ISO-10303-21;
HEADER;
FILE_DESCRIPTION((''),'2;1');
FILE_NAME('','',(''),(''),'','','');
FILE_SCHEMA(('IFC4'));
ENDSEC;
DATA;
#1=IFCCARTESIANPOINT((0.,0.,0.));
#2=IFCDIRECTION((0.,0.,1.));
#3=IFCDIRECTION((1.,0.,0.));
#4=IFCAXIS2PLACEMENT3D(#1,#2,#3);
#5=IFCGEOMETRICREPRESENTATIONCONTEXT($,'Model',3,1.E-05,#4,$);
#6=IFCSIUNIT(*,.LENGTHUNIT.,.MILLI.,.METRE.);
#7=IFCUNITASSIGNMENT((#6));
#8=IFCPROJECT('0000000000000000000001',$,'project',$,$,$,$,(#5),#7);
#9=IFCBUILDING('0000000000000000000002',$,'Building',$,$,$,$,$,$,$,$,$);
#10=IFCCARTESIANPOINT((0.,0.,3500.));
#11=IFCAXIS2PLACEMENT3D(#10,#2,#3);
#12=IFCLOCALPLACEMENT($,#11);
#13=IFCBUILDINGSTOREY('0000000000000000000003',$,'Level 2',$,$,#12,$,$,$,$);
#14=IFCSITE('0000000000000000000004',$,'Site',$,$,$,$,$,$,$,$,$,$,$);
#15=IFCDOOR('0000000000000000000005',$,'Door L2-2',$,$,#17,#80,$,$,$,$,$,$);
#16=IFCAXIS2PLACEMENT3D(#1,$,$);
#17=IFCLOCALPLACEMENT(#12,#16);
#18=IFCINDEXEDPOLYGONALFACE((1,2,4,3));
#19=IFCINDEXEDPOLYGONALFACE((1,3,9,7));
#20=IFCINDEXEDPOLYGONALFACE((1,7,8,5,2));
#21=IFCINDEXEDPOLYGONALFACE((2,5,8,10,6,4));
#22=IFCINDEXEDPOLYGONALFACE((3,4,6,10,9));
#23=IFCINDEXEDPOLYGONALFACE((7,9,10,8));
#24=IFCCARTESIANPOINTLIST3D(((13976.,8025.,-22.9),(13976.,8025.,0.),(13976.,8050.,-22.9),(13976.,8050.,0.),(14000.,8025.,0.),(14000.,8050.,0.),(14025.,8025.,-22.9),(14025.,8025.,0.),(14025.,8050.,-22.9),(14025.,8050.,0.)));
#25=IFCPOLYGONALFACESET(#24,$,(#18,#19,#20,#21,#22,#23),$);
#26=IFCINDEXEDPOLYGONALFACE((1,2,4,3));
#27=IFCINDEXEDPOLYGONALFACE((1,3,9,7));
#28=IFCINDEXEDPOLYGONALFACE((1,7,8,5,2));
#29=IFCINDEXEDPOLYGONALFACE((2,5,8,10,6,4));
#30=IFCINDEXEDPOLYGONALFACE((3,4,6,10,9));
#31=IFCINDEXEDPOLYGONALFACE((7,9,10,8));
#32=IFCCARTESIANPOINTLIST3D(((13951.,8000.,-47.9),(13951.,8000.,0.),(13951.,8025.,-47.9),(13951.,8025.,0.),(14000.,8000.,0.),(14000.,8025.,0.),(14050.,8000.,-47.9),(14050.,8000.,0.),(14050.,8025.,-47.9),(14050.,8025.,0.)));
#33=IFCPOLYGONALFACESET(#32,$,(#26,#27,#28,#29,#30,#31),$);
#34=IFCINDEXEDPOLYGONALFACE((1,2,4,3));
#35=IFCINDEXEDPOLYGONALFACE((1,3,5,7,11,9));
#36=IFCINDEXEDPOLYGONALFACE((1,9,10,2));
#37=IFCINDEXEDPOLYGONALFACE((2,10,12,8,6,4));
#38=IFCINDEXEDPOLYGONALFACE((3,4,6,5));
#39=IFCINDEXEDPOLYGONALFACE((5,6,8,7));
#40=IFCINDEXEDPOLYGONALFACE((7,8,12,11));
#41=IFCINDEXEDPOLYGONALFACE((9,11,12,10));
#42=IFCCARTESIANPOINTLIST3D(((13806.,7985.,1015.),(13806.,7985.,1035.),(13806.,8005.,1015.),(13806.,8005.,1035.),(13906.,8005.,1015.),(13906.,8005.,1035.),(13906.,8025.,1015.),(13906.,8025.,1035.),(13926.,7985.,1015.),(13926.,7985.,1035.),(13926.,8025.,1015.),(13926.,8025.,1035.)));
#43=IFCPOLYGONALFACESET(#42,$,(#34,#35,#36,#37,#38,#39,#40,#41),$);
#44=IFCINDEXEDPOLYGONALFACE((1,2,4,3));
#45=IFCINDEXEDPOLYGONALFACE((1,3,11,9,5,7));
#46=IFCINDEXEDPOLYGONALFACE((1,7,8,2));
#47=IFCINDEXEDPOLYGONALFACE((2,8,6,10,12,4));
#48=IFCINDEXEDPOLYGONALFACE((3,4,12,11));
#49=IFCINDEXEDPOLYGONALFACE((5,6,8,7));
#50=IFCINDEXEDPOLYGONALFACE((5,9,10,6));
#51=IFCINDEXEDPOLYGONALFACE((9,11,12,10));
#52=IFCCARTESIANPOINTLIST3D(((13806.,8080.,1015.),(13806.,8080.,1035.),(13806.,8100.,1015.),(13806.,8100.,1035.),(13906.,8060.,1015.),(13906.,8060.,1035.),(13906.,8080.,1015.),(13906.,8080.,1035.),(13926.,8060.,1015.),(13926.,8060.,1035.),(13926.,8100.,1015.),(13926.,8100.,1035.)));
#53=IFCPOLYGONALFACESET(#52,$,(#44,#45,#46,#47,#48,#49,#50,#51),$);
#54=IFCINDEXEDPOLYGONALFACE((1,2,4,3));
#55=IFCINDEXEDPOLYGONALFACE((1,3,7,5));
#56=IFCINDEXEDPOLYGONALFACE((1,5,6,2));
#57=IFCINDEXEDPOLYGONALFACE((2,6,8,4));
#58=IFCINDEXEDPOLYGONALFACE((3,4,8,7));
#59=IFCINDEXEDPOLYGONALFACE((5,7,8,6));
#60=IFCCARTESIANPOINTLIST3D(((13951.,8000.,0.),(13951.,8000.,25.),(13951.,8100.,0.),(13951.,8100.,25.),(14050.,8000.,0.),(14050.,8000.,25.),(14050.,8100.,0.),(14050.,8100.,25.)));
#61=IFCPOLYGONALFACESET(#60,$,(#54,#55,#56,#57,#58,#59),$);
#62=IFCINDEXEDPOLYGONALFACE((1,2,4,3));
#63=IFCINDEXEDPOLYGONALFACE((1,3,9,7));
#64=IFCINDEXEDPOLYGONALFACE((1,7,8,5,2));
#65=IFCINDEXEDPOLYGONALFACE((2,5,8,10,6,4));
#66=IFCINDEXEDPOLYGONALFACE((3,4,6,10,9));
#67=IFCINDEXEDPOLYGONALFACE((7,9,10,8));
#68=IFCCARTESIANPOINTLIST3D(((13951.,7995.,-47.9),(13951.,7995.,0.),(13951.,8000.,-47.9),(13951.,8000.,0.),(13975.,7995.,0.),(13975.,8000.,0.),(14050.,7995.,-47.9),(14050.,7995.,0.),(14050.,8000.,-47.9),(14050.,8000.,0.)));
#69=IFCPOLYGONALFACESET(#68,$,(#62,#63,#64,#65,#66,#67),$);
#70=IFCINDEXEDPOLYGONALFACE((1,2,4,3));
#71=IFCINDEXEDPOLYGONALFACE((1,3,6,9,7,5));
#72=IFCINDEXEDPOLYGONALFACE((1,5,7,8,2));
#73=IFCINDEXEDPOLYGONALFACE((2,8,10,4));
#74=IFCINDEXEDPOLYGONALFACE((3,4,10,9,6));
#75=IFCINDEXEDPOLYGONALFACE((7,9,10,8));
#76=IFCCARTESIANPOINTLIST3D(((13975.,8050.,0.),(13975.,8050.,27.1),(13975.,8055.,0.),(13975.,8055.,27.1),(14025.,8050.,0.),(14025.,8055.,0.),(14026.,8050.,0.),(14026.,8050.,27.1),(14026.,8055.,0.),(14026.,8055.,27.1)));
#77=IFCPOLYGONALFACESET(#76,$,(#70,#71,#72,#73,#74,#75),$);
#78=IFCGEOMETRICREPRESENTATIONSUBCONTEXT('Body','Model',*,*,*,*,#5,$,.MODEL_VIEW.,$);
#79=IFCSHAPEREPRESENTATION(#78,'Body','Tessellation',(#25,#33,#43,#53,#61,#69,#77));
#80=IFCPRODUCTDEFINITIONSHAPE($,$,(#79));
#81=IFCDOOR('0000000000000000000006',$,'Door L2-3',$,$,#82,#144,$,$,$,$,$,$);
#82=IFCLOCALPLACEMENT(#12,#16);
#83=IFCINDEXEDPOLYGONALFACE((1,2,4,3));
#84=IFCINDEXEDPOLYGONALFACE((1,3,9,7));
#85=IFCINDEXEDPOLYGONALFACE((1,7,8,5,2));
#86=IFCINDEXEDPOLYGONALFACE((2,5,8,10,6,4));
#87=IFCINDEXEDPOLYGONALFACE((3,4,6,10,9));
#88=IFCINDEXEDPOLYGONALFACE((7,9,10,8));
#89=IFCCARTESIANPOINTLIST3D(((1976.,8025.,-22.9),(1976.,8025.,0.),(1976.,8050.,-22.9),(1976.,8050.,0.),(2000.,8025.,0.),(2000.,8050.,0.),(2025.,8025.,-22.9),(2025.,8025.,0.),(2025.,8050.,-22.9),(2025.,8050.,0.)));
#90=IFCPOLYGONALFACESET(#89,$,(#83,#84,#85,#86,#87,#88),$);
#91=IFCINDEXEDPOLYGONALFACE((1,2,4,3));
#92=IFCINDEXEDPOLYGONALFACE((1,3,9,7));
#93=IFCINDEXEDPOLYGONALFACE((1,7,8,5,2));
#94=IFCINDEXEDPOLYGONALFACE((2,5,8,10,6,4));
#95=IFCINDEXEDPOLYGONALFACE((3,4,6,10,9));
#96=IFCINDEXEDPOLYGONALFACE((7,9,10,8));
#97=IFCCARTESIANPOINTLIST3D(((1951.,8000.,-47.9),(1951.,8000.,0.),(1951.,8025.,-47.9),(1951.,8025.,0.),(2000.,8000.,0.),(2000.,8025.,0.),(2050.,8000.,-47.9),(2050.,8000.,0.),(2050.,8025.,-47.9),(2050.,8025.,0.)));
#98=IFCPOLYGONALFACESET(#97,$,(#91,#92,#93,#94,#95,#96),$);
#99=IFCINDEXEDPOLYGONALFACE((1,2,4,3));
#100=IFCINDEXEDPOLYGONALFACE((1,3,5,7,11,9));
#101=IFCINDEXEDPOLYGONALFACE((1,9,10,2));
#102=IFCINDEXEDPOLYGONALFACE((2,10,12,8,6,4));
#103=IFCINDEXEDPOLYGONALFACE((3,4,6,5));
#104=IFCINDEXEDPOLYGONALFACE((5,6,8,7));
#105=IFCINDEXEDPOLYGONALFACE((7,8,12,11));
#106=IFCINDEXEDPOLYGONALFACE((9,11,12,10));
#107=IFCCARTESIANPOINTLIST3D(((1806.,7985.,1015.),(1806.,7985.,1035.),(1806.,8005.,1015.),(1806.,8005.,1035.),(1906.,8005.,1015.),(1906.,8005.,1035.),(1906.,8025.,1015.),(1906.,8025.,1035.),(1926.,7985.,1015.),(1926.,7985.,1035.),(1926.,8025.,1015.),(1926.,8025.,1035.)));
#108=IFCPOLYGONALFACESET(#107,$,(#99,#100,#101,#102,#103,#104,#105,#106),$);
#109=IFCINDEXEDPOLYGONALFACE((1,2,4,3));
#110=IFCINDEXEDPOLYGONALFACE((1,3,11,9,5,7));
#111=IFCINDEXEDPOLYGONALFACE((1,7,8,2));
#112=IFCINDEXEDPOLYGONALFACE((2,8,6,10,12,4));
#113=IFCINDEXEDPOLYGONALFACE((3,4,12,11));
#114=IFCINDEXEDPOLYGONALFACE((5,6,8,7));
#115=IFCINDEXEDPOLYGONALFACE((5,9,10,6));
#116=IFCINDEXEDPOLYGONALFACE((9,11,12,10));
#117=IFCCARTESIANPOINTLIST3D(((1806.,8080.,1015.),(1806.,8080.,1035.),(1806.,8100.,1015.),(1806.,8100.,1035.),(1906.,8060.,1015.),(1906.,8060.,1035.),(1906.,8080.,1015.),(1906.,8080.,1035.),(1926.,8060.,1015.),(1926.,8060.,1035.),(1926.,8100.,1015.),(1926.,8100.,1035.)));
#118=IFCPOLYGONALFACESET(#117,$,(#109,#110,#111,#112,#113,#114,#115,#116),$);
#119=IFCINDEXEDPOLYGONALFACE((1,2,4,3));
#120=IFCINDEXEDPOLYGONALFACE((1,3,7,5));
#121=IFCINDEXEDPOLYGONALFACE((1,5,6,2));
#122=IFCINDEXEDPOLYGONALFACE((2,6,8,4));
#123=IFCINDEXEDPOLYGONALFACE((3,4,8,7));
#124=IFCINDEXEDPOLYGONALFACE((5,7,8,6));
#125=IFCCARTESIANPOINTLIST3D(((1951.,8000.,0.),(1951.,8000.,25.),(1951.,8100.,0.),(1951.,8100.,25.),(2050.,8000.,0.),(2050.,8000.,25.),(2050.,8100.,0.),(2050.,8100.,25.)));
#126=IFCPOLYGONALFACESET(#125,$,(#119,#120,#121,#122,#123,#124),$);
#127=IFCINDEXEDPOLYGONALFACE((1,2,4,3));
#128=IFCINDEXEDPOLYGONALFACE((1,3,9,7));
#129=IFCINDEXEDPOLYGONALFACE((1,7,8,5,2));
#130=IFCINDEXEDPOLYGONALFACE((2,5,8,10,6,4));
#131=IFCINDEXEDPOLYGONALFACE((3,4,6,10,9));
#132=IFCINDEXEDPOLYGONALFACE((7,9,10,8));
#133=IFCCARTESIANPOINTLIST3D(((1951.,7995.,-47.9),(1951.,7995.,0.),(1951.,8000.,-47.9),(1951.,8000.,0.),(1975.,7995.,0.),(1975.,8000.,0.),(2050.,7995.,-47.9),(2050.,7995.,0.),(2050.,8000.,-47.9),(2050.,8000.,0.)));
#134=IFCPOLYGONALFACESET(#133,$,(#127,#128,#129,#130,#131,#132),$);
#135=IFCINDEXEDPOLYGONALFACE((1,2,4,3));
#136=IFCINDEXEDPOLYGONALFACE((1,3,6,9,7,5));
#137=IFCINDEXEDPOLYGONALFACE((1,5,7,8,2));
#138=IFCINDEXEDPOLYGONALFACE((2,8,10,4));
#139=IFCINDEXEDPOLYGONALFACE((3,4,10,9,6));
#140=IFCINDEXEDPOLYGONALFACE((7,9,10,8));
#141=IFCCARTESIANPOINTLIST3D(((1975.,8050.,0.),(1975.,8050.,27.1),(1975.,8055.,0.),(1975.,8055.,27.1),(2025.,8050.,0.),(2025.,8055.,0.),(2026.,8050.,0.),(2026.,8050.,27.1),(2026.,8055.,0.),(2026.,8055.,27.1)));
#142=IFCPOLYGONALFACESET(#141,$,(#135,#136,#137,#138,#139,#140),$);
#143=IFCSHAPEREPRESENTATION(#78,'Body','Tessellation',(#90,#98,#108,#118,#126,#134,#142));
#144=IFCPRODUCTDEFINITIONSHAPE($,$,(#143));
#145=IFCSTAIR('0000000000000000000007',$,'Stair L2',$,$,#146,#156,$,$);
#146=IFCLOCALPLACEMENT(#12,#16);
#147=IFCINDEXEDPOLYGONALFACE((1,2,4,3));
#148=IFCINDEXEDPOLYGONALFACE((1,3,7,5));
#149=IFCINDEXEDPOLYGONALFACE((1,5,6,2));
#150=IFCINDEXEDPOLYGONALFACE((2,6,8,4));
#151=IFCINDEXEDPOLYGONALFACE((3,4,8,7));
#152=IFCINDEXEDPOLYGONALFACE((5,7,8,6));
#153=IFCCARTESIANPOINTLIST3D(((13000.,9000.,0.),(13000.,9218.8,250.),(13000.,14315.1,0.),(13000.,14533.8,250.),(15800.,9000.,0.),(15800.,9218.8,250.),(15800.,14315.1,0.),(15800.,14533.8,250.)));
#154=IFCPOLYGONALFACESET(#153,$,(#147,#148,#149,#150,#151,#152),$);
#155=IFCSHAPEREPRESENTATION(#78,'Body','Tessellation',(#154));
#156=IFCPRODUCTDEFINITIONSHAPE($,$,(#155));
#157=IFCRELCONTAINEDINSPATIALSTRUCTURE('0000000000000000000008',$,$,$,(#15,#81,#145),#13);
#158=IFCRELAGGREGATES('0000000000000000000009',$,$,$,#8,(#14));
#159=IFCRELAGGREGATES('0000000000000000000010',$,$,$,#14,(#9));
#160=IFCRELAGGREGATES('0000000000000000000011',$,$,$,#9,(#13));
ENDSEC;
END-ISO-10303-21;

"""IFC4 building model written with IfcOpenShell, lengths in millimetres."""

from ifc_helpers import new_model, si_unit, frame, origin_with_axes, place, context, subcontext, project, spatial, line, indexed_curve, outline, extrude, element, save


model = new_model("IFC4")

# Units and contexts
model_context = context("Model", 3, precision=1e-05, world=origin_with_axes())
body_context = subcontext(model_context, "Body", "Model", "MODEL_VIEW")
ifc_project = project(units=[si_unit("LENGTHUNIT", "METRE", prefix="MILLI")], contexts=[model_context])

# Site, building, storey
site = spatial("IfcSite", under=ifc_project, Name="Site")
building = spatial("IfcBuilding", under=site, Name="Building")
storey_placement = place(None, frame((0.0, 0.0, 3500.0), z_axis=(0.0, 0.0, 1.0), x_axis=(1.0, 0.0, 0.0)))
storey = spatial("IfcBuildingStorey", under=building, at=storey_placement, Name="Level 2")

# Doors
door_1_placement = place(storey_placement, frame((14000.0, 8000.0, 0.0), z_axis=(0.0, 0.0, 1.0), x_axis=(1.0, 0.0, 0.0)))
element("IfcDoor", 1, at=door_1_placement, inside=storey, Name="Door L2-2", context=body_context, shape_type="SweptSolid", body=[
    extrude(outline(indexed_curve([(0.0, 0.0), (0.0, 2.1), (1.0, 2.1), (1.0, 0.0), (-24.0, 0.0), (-24.0, -22.9), (25.0, -22.9), (25.0, 0.0)], segments=[line(1, 2, 3, 4, 5, 6, 7, 8, 1)])), frame((0.0, 25.0, 0.0), z_axis=(0.0, -1.0, 0.0), x_axis=(1.0, 0.0, 0.0)), (0.0, 0.0, -1.0), 25.0),
    extrude(outline(indexed_curve([(0.0, 0.0), (0.0, 2.1), (1.0, 2.1), (1.0, 0.0), (-49.0, 0.0), (-49.0, -47.9), (50.0, -47.9), (50.0, 0.0)], segments=[line(1, 2, 3, 4, 5, 6, 7, 8, 1)])), frame((0.0, 0.0, 0.0), z_axis=(0.0, -1.0, 0.0), x_axis=(1.0, 0.0, 0.0)), (0.0, 0.0, -1.0), 25.0),
    extrude(outline(indexed_curve([(0.0, 0.0), (-49.0, 0.0), (-49.0, 35.0), (0.0, 35.0)], segments=[line(1, 2, 3, 4, 1)])), frame((25.0, 25.0, 25.0), z_axis=(0.0, 0.0, 1.0), x_axis=(1.0, 0.0, 0.0)), (0.0, 0.0, 1.0), -47.9),
    extrude(outline(indexed_curve([(0.0, 0.0), (0.0, -40.0), (-120.0, -40.0), (-120.0, -20.0), (-20.0, -20.0), (-20.0, 0.0)], segments=[line(1, 2, 3, 4, 5, 6, 1)])), frame((-74.0, 25.0, 1015.0), z_axis=(0.0, 0.0, 1.0), x_axis=(1.0, 0.0, 0.0)), (0.0, 0.0, 1.0), 20.0),
    extrude(outline(indexed_curve([(0.0, 0.0), (0.0, 40.0), (-120.0, 40.0), (-120.0, 20.0), (-20.0, 20.0), (-20.0, 0.0)], segments=[line(1, 2, 3, 4, 5, 6, 1)])), frame((-74.0, 60.0, 1015.0), z_axis=(0.0, 0.0, 1.0), x_axis=(1.0, 0.0, 0.0)), (0.0, 0.0, 1.0), 20.0),
    extrude(outline(indexed_curve([(0.0, 0.0), (-99.0, 0.0), (-99.0, 100.0), (0.0, 100.0)], segments=[line(1, 2, 3, 4, 1)])), frame((50.0, 0.0, 0.0), z_axis=(0.0, 0.0, 1.0), x_axis=(1.0, 0.0, 0.0)), (0.0, 0.0, 1.0), 25.0),
    extrude(outline(indexed_curve([(0.0, 0.0), (0.0, 27.1), (51.0, 27.1), (51.0, 0.0), (-24.0, 0.0), (-24.0, -47.9), (75.0, -47.9), (75.0, 0.0)], segments=[line(1, 2, 3, 4, 5, 6, 7, 8, 1)])), frame((-25.0, -5.0, 0.0), z_axis=(0.0, -1.0, 0.0), x_axis=(1.0, 0.0, 0.0)), (0.0, 0.0, -1.0), 5.0),
    extrude(outline(indexed_curve([(0.0, 0.0), (0.0, 27.1), (51.0, 27.1), (51.0, 0.0), (1.0, 0.0), (1.0, -22.9), (50.0, -22.9), (50.0, 0.0)], segments=[line(1, 2, 3, 4, 5, 6, 7, 8, 1)])), frame((-25.0, 50.0, 0.0), z_axis=(0.0, -1.0, 0.0), x_axis=(1.0, 0.0, 0.0)), (0.0, 0.0, -1.0), 5.0),
])
door_2_placement = place(storey_placement, frame((2000.0, 8000.0, 0.0), z_axis=(0.0, 0.0, 1.0), x_axis=(1.0, 0.0, 0.0)))
element("IfcDoor", 2, at=door_2_placement, inside=storey, Name="Door L2-3", context=body_context, shape_type="SweptSolid", body=[
    extrude(outline(indexed_curve([(0.0, 0.0), (0.0, 2.1), (1.0, 2.1), (1.0, 0.0), (-24.0, 0.0), (-24.0, -22.9), (25.0, -22.9), (25.0, 0.0)], segments=[line(1, 2, 3, 4, 5, 6, 7, 8, 1)])), frame((0.0, 25.0, 0.0), z_axis=(0.0, -1.0, 0.0), x_axis=(1.0, 0.0, 0.0)), (0.0, 0.0, -1.0), 25.0),
    extrude(outline(indexed_curve([(0.0, 0.0), (0.0, 2.1), (1.0, 2.1), (1.0, 0.0), (-49.0, 0.0), (-49.0, -47.9), (50.0, -47.9), (50.0, 0.0)], segments=[line(1, 2, 3, 4, 5, 6, 7, 8, 1)])), frame((0.0, 0.0, 0.0), z_axis=(0.0, -1.0, 0.0), x_axis=(1.0, 0.0, 0.0)), (0.0, 0.0, -1.0), 25.0),
    extrude(outline(indexed_curve([(0.0, 0.0), (-49.0, 0.0), (-49.0, 35.0), (0.0, 35.0)], segments=[line(1, 2, 3, 4, 1)])), frame((25.0, 25.0, 25.0), z_axis=(0.0, 0.0, 1.0), x_axis=(1.0, 0.0, 0.0)), (0.0, 0.0, 1.0), -47.9),
    extrude(outline(indexed_curve([(0.0, 0.0), (0.0, -40.0), (-120.0, -40.0), (-120.0, -20.0), (-20.0, -20.0), (-20.0, 0.0)], segments=[line(1, 2, 3, 4, 5, 6, 1)])), frame((-74.0, 25.0, 1015.0), z_axis=(0.0, 0.0, 1.0), x_axis=(1.0, 0.0, 0.0)), (0.0, 0.0, 1.0), 20.0),
    extrude(outline(indexed_curve([(0.0, 0.0), (0.0, 40.0), (-120.0, 40.0), (-120.0, 20.0), (-20.0, 20.0), (-20.0, 0.0)], segments=[line(1, 2, 3, 4, 5, 6, 1)])), frame((-74.0, 60.0, 1015.0), z_axis=(0.0, 0.0, 1.0), x_axis=(1.0, 0.0, 0.0)), (0.0, 0.0, 1.0), 20.0),
    extrude(outline(indexed_curve([(0.0, 0.0), (-99.0, 0.0), (-99.0, 100.0), (0.0, 100.0)], segments=[line(1, 2, 3, 4, 1)])), frame((50.0, 0.0, 0.0), z_axis=(0.0, 0.0, 1.0), x_axis=(1.0, 0.0, 0.0)), (0.0, 0.0, 1.0), 25.0),
    extrude(outline(indexed_curve([(0.0, 0.0), (0.0, 27.1), (51.0, 27.1), (51.0, 0.0), (-24.0, 0.0), (-24.0, -47.9), (75.0, -47.9), (75.0, 0.0)], segments=[line(1, 2, 3, 4, 5, 6, 7, 8, 1)])), frame((-25.0, -5.0, 0.0), z_axis=(0.0, -1.0, 0.0), x_axis=(1.0, 0.0, 0.0)), (0.0, 0.0, -1.0), 5.0),
    extrude(outline(indexed_curve([(0.0, 0.0), (0.0, 27.1), (51.0, 27.1), (51.0, 0.0), (1.0, 0.0), (1.0, -22.9), (50.0, -22.9), (50.0, 0.0)], segments=[line(1, 2, 3, 4, 5, 6, 7, 8, 1)])), frame((-25.0, 50.0, 0.0), z_axis=(0.0, -1.0, 0.0), x_axis=(1.0, 0.0, 0.0)), (0.0, 0.0, -1.0), 5.0),
])

# Stair
stair_placement = place(storey_placement, frame((13000.0, 9000.0, 0.0), z_axis=(0.0, 0.0, 1.0), x_axis=(1.0, 0.0, 0.0)))
element("IfcStair", 3, at=stair_placement, inside=storey, Name="Stair L2", context=body_context, shape_type="SweptSolid", body=[
    extrude(outline(indexed_curve([(0.0, 0.0), (2800.0, 0.0), (2800.0, 5315.1), (0.0, 5315.1), (0.0, 0.0)])), None, (0.0, 0.658505, 0.752577), 332.2),
])

save(model, "model.ifc")
